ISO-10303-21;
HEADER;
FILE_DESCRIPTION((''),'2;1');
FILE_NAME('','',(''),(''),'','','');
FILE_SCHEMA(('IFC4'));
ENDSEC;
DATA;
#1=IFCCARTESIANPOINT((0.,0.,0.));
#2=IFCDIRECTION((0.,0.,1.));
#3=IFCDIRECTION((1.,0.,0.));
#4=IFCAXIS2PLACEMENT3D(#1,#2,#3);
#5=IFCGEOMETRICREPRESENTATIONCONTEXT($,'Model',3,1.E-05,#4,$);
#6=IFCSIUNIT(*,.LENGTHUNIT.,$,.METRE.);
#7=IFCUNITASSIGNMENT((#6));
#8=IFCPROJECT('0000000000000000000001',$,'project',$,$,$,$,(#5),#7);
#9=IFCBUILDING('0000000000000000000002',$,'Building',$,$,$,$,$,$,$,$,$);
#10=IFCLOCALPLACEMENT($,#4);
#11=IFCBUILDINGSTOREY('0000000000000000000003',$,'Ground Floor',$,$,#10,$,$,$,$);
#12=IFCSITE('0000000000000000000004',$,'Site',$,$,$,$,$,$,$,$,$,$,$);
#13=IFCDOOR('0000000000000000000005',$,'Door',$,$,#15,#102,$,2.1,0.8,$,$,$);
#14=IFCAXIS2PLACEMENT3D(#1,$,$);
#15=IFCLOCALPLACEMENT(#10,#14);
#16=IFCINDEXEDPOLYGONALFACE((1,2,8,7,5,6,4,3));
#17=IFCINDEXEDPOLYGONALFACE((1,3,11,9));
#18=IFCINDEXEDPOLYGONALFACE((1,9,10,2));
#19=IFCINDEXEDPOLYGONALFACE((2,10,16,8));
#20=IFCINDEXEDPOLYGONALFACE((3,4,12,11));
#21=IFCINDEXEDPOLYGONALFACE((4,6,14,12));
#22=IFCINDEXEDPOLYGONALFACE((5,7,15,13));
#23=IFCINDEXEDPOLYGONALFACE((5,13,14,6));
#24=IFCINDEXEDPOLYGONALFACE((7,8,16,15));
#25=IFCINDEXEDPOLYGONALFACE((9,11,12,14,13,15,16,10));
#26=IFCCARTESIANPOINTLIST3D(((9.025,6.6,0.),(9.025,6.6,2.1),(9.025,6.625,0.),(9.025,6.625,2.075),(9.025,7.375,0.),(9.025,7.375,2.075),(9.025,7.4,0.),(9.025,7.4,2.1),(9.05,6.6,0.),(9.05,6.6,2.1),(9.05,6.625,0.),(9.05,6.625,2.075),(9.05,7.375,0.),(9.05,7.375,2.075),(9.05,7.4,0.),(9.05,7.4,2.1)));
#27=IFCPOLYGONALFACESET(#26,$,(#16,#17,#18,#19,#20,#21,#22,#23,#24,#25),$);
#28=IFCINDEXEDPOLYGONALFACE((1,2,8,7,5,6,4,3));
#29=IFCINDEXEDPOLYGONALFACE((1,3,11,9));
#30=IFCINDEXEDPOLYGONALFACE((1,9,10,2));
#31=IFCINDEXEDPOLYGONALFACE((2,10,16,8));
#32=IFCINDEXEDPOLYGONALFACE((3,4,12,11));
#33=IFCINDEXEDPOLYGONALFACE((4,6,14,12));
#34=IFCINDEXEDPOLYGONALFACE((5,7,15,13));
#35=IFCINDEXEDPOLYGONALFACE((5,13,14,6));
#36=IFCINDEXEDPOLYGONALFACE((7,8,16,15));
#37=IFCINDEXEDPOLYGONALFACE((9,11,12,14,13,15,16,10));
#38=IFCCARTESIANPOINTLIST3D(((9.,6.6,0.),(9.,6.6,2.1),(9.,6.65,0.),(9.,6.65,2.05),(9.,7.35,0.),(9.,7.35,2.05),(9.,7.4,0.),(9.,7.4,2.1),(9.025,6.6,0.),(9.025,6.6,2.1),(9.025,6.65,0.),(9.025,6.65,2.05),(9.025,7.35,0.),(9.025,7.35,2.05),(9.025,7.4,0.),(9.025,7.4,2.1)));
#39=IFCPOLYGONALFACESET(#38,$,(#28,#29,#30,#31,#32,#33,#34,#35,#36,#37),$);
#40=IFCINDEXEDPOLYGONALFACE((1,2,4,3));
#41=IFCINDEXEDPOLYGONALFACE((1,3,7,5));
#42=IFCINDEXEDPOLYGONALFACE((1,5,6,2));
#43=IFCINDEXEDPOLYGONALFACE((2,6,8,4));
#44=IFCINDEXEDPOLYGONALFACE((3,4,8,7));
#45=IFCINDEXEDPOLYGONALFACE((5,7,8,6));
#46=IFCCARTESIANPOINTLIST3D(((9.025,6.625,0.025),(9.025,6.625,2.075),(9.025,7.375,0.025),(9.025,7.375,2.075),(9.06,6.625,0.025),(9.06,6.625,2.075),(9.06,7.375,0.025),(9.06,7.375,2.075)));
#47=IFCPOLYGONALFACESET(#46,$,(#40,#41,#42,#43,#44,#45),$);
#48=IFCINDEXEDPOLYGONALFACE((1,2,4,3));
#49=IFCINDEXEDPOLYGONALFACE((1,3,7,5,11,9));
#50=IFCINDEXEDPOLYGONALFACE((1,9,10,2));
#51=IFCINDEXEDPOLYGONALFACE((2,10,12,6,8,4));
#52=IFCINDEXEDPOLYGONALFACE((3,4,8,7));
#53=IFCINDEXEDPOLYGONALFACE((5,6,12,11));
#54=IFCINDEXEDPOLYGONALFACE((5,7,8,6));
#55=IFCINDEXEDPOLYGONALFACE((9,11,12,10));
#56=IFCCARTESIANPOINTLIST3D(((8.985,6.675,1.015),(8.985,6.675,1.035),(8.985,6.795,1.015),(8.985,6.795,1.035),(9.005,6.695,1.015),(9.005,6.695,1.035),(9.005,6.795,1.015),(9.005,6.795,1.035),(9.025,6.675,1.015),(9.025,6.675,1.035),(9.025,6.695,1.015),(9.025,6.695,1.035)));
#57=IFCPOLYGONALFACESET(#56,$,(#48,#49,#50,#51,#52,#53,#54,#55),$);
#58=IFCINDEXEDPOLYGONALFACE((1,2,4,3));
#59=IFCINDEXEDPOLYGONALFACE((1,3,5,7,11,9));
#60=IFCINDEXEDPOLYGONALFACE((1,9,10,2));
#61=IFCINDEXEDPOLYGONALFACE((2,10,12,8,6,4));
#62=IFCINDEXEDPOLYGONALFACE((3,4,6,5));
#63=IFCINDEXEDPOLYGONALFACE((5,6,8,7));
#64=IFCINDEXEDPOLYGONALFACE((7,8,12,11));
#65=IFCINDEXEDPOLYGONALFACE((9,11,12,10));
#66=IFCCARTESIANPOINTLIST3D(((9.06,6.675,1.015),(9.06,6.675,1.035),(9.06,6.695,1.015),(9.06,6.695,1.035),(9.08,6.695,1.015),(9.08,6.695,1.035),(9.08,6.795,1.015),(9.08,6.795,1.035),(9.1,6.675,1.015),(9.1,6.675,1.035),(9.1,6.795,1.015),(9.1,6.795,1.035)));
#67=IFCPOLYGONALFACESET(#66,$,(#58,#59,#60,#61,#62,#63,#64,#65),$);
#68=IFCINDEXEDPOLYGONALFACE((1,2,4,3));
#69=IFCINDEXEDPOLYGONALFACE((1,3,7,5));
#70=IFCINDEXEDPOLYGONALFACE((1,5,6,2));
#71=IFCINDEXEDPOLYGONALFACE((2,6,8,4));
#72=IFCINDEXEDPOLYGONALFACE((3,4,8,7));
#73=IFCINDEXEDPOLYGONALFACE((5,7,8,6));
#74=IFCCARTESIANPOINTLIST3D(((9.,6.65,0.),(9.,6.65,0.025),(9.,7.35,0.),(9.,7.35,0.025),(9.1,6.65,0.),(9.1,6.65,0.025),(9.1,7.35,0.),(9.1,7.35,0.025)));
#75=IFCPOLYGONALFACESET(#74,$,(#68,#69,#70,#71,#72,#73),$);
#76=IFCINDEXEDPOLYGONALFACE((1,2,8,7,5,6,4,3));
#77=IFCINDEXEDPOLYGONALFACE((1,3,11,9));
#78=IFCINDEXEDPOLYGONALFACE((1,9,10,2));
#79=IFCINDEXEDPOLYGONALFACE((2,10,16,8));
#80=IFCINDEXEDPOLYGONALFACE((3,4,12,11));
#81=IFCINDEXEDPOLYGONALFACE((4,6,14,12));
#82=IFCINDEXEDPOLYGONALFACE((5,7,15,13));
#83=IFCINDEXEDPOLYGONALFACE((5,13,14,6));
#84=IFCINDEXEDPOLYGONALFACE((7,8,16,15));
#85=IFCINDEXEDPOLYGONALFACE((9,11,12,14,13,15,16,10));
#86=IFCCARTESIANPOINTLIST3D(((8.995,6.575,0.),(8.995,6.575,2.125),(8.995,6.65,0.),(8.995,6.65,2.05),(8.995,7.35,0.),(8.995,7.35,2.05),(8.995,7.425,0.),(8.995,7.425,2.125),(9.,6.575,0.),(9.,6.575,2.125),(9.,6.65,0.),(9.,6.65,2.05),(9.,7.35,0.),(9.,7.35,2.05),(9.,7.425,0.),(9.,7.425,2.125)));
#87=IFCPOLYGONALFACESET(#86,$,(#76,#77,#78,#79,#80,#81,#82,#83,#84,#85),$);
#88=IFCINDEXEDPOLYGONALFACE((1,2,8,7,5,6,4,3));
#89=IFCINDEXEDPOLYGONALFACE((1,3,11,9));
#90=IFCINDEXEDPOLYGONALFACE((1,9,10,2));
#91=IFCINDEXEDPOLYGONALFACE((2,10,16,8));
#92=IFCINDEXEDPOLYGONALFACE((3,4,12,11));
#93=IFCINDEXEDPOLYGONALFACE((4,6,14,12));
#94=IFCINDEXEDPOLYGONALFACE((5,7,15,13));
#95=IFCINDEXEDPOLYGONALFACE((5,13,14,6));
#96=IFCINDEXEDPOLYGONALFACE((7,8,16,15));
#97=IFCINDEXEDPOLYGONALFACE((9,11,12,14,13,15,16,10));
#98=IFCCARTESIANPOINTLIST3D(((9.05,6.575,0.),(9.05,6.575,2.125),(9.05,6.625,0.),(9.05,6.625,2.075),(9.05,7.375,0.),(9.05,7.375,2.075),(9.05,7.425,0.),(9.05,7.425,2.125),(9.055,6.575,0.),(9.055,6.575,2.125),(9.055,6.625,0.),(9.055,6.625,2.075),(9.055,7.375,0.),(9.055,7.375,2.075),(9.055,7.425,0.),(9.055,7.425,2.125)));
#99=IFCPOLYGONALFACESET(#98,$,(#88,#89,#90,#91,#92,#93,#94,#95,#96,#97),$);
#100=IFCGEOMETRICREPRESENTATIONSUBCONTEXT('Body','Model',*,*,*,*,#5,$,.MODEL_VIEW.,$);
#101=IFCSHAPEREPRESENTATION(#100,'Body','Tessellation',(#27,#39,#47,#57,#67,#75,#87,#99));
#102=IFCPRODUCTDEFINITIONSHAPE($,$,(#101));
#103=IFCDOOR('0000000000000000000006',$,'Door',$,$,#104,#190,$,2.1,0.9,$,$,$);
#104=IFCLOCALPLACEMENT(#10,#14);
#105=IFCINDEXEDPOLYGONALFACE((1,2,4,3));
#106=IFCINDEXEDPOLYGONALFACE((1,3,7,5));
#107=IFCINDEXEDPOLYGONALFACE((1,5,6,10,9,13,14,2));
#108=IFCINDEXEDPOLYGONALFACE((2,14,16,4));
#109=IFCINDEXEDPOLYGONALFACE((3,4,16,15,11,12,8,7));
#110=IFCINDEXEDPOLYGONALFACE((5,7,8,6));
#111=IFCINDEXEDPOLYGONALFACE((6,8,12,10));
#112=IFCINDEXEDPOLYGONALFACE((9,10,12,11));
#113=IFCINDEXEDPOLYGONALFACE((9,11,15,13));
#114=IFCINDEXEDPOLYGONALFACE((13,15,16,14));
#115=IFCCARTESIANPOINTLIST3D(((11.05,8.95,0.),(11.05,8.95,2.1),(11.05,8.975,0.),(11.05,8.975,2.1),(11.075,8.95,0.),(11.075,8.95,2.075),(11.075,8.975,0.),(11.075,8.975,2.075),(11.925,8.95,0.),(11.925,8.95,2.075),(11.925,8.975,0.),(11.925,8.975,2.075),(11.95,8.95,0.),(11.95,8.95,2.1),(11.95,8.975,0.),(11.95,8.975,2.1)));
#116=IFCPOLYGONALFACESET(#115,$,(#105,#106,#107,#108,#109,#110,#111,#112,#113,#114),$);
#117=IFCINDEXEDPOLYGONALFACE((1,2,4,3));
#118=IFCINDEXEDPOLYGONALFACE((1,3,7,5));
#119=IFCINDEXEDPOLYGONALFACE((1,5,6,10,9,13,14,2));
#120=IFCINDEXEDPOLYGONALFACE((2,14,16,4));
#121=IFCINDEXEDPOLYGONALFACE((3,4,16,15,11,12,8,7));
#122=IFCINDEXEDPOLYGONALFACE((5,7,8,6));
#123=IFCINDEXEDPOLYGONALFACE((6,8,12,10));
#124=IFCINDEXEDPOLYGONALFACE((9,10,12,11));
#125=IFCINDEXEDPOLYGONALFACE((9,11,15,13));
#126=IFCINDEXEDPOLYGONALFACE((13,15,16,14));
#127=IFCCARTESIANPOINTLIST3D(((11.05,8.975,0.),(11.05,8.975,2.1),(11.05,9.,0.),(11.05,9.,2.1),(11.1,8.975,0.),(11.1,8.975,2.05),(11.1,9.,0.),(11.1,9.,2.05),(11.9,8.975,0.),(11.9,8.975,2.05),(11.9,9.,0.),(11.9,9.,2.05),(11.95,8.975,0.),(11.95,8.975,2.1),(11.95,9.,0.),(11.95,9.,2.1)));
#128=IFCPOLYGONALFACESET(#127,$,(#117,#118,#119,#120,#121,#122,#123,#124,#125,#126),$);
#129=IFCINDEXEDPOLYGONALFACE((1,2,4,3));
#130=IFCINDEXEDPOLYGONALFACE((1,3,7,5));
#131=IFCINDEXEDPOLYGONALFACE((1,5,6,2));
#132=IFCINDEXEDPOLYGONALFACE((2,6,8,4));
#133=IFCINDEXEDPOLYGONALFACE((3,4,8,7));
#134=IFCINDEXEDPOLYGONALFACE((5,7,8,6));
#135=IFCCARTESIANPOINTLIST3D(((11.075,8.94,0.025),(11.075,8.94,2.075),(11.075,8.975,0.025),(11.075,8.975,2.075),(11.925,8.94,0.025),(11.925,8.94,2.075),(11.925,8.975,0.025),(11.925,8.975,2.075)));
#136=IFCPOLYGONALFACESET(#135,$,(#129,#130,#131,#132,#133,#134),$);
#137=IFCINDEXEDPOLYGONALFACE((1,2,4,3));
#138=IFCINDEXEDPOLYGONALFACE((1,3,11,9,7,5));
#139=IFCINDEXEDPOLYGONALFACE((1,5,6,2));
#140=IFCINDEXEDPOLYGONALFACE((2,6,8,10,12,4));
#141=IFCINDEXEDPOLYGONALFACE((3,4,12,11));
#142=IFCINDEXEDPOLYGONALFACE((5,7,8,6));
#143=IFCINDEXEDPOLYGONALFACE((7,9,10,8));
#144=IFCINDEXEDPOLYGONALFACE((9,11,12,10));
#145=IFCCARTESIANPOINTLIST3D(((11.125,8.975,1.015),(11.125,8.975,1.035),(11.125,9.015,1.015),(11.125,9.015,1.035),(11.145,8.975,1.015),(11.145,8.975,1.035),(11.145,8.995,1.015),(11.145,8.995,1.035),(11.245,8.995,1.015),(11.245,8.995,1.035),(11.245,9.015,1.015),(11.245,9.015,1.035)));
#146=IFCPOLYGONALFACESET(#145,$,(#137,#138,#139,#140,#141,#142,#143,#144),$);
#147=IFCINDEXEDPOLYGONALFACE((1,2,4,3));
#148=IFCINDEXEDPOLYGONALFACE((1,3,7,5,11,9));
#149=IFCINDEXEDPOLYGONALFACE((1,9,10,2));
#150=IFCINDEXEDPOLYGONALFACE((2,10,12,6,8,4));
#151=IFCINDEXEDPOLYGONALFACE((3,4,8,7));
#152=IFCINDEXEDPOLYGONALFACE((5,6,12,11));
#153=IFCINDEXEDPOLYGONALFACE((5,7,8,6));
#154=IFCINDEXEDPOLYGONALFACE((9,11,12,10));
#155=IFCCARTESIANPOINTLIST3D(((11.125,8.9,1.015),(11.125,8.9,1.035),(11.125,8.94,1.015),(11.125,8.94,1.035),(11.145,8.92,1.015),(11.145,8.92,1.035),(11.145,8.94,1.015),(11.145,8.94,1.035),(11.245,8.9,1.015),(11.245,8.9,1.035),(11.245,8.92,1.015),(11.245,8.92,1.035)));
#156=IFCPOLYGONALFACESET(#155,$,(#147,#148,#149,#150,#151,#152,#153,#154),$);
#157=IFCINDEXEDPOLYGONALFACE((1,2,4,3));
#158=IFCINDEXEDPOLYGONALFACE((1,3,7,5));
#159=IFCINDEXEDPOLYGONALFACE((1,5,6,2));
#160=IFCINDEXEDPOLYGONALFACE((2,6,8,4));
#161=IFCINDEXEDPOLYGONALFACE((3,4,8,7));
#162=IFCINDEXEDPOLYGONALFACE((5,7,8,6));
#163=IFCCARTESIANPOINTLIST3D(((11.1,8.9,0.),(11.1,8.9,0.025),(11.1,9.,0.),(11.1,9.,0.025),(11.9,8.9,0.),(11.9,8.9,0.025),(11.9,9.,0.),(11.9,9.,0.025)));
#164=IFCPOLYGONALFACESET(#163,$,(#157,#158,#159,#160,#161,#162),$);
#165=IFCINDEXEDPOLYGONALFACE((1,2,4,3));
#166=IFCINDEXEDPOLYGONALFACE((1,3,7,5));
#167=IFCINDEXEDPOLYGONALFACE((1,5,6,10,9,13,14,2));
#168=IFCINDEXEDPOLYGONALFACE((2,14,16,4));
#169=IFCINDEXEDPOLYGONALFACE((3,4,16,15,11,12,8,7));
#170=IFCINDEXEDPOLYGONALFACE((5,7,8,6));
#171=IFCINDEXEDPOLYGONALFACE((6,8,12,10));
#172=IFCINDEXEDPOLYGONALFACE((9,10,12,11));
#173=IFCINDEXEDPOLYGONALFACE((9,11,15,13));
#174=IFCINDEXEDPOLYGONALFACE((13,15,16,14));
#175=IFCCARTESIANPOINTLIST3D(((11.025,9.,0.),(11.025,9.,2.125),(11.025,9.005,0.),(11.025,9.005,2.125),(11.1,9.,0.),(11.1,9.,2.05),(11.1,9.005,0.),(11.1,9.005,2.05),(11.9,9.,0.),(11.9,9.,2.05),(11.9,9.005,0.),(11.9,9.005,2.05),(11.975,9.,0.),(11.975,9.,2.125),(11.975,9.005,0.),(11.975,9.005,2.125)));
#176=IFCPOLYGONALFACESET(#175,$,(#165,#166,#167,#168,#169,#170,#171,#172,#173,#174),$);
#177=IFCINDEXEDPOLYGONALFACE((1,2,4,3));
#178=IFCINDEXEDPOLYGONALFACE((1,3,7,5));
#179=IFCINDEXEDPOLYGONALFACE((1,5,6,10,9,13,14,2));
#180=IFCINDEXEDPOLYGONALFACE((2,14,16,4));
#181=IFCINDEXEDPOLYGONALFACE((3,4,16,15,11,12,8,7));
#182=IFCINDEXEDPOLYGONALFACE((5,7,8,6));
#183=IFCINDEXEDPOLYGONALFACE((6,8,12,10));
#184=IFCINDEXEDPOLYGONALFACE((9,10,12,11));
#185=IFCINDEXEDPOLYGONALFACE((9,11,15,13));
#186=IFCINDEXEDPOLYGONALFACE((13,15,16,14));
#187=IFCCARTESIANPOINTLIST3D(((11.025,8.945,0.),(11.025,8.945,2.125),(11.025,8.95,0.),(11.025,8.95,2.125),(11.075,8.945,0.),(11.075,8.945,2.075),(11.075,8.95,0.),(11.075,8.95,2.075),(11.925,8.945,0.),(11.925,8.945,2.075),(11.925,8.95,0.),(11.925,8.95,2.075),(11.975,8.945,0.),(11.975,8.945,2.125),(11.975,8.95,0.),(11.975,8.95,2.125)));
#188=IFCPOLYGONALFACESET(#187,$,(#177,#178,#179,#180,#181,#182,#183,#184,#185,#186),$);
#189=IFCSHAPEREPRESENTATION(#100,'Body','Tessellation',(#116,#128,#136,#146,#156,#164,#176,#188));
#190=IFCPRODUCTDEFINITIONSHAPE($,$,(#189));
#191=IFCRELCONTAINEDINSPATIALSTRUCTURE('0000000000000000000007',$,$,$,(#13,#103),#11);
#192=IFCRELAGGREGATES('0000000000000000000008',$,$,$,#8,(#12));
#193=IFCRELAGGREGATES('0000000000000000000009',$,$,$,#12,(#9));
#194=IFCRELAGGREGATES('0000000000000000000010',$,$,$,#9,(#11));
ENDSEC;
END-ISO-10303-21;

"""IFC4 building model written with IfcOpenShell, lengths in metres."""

from ifc_helpers import new_model, si_unit, frame, origin_with_axes, place, context, subcontext, project, spatial, line, indexed_curve, outline, extrude, element, save


model = new_model("IFC4")

# Units and contexts
model_context = context("Model", 3, precision=1e-05, world=origin_with_axes())
body_context = subcontext(model_context, "Body", "Model", "MODEL_VIEW")
ifc_project = project(units=[si_unit("LENGTHUNIT", "METRE")], contexts=[model_context])

# Site, building, storey
site = spatial("IfcSite", under=ifc_project, Name="Site")
building = spatial("IfcBuilding", under=site, Name="Building")
storey_placement = place(None, origin_with_axes())
storey = spatial("IfcBuildingStorey", under=building, at=storey_placement, Name="Ground Floor")

# Doors
door_1_placement = place(storey_placement, frame((9.0, 7.4, 0.0), z_axis=(0.0, 0.0, 1.0), x_axis=(0.0, -1.0, 0.0)))
element("IfcDoor", 1, at=door_1_placement, inside=storey, Name="Door", OverallHeight=2.1, OverallWidth=0.8, context=body_context, shape_type="SweptSolid", body=[
    extrude(outline(indexed_curve([(0.0, 0.0), (0.0, 2.1), (0.8, 2.1), (0.8, 0.0), (0.775, 0.0), (0.775, 2.075), (0.025, 2.075), (0.025, 0.0)], segments=[line(1, 2, 3, 4, 5, 6, 7, 8, 1)])), frame((0.0, 0.025, 0.0), z_axis=(0.0, -1.0, 0.0), x_axis=(1.0, 0.0, 0.0)), (0.0, 0.0, -1.0), 0.025),
    extrude(outline(indexed_curve([(0.0, 0.0), (0.0, 2.1), (0.8, 2.1), (0.8, 0.0), (0.75, 0.0), (0.75, 2.05), (0.05, 2.05), (0.05, 0.0)], segments=[line(1, 2, 3, 4, 5, 6, 7, 8, 1)])), frame((0.0, 0.0, 0.0), z_axis=(0.0, -1.0, 0.0), x_axis=(1.0, 0.0, 0.0)), (0.0, 0.0, -1.0), 0.025),
    extrude(outline(indexed_curve([(0.0, 0.0), (0.75, 0.0), (0.75, 0.035), (0.0, 0.035)], segments=[line(1, 2, 3, 4, 1)])), frame((0.025, 0.025, 0.025), z_axis=(0.0, 0.0, 1.0), x_axis=(1.0, 0.0, 0.0)), (0.0, 0.0, 1.0), 2.05),
    extrude(outline(indexed_curve([(0.0, 0.0), (0.0, -0.04), (-0.12, -0.04), (-0.12, -0.02), (-0.02, -0.02), (-0.02, 0.0)], segments=[line(1, 2, 3, 4, 5, 6, 1)])), frame((0.725, 0.025, 1.015), z_axis=(0.0, 0.0, 1.0), x_axis=(1.0, 0.0, 0.0)), (0.0, 0.0, 1.0), 0.02),
    extrude(outline(indexed_curve([(0.0, 0.0), (0.0, 0.04), (-0.12, 0.04), (-0.12, 0.02), (-0.02, 0.02), (-0.02, 0.0)], segments=[line(1, 2, 3, 4, 5, 6, 1)])), frame((0.725, 0.06, 1.015), z_axis=(0.0, 0.0, 1.0), x_axis=(1.0, 0.0, 0.0)), (0.0, 0.0, 1.0), 0.02),
    extrude(outline(indexed_curve([(0.0, 0.0), (0.7, 0.0), (0.7, 0.1), (0.0, 0.1)], segments=[line(1, 2, 3, 4, 1)])), frame((0.05, 0.0, 0.0), z_axis=(0.0, 0.0, 1.0), x_axis=(1.0, 0.0, 0.0)), (0.0, 0.0, 1.0), 0.025),
    extrude(outline(indexed_curve([(0.0, 0.0), (0.0, 2.125), (0.85, 2.125), (0.85, 0.0), (0.775, 0.0), (0.775, 2.05), (0.075, 2.05), (0.075, 0.0)], segments=[line(1, 2, 3, 4, 5, 6, 7, 8, 1)])), frame((-0.025, -0.005, 0.0), z_axis=(0.0, -1.0, 0.0), x_axis=(1.0, 0.0, 0.0)), (0.0, 0.0, -1.0), 0.005),
    extrude(outline(indexed_curve([(0.0, 0.0), (0.0, 2.125), (0.85, 2.125), (0.85, 0.0), (0.8, 0.0), (0.8, 2.075), (0.05, 2.075), (0.05, 0.0)], segments=[line(1, 2, 3, 4, 5, 6, 7, 8, 1)])), frame((-0.025, 0.05, 0.0), z_axis=(0.0, -1.0, 0.0), x_axis=(1.0, 0.0, 0.0)), (0.0, 0.0, -1.0), 0.005),
])
door_2_placement = place(storey_placement, frame((11.95, 9.0, 0.0), z_axis=(0.0, 0.0, 1.0), x_axis=(-1.0, 0.0, 0.0)))
element("IfcDoor", 2, at=door_2_placement, inside=storey, Name="Door", OverallHeight=2.1, OverallWidth=0.9, context=body_context, shape_type="SweptSolid", body=[
    extrude(outline(indexed_curve([(0.0, 0.0), (0.0, 2.1), (0.9, 2.1), (0.9, 0.0), (0.875, 0.0), (0.875, 2.075), (0.025, 2.075), (0.025, 0.0)], segments=[line(1, 2, 3, 4, 5, 6, 7, 8, 1)])), frame((0.0, 0.025, 0.0), z_axis=(0.0, -1.0, 0.0), x_axis=(1.0, 0.0, 0.0)), (0.0, 0.0, -1.0), 0.025),
    extrude(outline(indexed_curve([(0.0, 0.0), (0.0, 2.1), (0.9, 2.1), (0.9, 0.0), (0.85, 0.0), (0.85, 2.05), (0.05, 2.05), (0.05, 0.0)], segments=[line(1, 2, 3, 4, 5, 6, 7, 8, 1)])), frame((0.0, 0.0, 0.0), z_axis=(0.0, -1.0, 0.0), x_axis=(1.0, 0.0, 0.0)), (0.0, 0.0, -1.0), 0.025),
    extrude(outline(indexed_curve([(0.0, 0.0), (0.85, 0.0), (0.85, 0.035), (0.0, 0.035)], segments=[line(1, 2, 3, 4, 1)])), frame((0.025, 0.025, 0.025), z_axis=(0.0, 0.0, 1.0), x_axis=(1.0, 0.0, 0.0)), (0.0, 0.0, 1.0), 2.05),
    extrude(outline(indexed_curve([(0.0, 0.0), (0.0, -0.04), (-0.12, -0.04), (-0.12, -0.02), (-0.02, -0.02), (-0.02, 0.0)], segments=[line(1, 2, 3, 4, 5, 6, 1)])), frame((0.825, 0.025, 1.015), z_axis=(0.0, 0.0, 1.0), x_axis=(1.0, 0.0, 0.0)), (0.0, 0.0, 1.0), 0.02),
    extrude(outline(indexed_curve([(0.0, 0.0), (0.0, 0.04), (-0.12, 0.04), (-0.12, 0.02), (-0.02, 0.02), (-0.02, 0.0)], segments=[line(1, 2, 3, 4, 5, 6, 1)])), frame((0.825, 0.06, 1.015), z_axis=(0.0, 0.0, 1.0), x_axis=(1.0, 0.0, 0.0)), (0.0, 0.0, 1.0), 0.02),
    extrude(outline(indexed_curve([(0.0, 0.0), (0.8, 0.0), (0.8, 0.1), (0.0, 0.1)], segments=[line(1, 2, 3, 4, 1)])), frame((0.05, 0.0, 0.0), z_axis=(0.0, 0.0, 1.0), x_axis=(1.0, 0.0, 0.0)), (0.0, 0.0, 1.0), 0.025),
    extrude(outline(indexed_curve([(0.0, 0.0), (0.0, 2.125), (0.95, 2.125), (0.95, 0.0), (0.875, 0.0), (0.875, 2.05), (0.075, 2.05), (0.075, 0.0)], segments=[line(1, 2, 3, 4, 5, 6, 7, 8, 1)])), frame((-0.025, -0.005, 0.0), z_axis=(0.0, -1.0, 0.0), x_axis=(1.0, 0.0, 0.0)), (0.0, 0.0, -1.0), 0.005),
    extrude(outline(indexed_curve([(0.0, 0.0), (0.0, 2.125), (0.95, 2.125), (0.95, 0.0), (0.9, 0.0), (0.9, 2.075), (0.05, 2.075), (0.05, 0.0)], segments=[line(1, 2, 3, 4, 5, 6, 7, 8, 1)])), frame((-0.025, 0.05, 0.0), z_axis=(0.0, -1.0, 0.0), x_axis=(1.0, 0.0, 0.0)), (0.0, 0.0, -1.0), 0.005),
])

save(model, "model.ifc")
